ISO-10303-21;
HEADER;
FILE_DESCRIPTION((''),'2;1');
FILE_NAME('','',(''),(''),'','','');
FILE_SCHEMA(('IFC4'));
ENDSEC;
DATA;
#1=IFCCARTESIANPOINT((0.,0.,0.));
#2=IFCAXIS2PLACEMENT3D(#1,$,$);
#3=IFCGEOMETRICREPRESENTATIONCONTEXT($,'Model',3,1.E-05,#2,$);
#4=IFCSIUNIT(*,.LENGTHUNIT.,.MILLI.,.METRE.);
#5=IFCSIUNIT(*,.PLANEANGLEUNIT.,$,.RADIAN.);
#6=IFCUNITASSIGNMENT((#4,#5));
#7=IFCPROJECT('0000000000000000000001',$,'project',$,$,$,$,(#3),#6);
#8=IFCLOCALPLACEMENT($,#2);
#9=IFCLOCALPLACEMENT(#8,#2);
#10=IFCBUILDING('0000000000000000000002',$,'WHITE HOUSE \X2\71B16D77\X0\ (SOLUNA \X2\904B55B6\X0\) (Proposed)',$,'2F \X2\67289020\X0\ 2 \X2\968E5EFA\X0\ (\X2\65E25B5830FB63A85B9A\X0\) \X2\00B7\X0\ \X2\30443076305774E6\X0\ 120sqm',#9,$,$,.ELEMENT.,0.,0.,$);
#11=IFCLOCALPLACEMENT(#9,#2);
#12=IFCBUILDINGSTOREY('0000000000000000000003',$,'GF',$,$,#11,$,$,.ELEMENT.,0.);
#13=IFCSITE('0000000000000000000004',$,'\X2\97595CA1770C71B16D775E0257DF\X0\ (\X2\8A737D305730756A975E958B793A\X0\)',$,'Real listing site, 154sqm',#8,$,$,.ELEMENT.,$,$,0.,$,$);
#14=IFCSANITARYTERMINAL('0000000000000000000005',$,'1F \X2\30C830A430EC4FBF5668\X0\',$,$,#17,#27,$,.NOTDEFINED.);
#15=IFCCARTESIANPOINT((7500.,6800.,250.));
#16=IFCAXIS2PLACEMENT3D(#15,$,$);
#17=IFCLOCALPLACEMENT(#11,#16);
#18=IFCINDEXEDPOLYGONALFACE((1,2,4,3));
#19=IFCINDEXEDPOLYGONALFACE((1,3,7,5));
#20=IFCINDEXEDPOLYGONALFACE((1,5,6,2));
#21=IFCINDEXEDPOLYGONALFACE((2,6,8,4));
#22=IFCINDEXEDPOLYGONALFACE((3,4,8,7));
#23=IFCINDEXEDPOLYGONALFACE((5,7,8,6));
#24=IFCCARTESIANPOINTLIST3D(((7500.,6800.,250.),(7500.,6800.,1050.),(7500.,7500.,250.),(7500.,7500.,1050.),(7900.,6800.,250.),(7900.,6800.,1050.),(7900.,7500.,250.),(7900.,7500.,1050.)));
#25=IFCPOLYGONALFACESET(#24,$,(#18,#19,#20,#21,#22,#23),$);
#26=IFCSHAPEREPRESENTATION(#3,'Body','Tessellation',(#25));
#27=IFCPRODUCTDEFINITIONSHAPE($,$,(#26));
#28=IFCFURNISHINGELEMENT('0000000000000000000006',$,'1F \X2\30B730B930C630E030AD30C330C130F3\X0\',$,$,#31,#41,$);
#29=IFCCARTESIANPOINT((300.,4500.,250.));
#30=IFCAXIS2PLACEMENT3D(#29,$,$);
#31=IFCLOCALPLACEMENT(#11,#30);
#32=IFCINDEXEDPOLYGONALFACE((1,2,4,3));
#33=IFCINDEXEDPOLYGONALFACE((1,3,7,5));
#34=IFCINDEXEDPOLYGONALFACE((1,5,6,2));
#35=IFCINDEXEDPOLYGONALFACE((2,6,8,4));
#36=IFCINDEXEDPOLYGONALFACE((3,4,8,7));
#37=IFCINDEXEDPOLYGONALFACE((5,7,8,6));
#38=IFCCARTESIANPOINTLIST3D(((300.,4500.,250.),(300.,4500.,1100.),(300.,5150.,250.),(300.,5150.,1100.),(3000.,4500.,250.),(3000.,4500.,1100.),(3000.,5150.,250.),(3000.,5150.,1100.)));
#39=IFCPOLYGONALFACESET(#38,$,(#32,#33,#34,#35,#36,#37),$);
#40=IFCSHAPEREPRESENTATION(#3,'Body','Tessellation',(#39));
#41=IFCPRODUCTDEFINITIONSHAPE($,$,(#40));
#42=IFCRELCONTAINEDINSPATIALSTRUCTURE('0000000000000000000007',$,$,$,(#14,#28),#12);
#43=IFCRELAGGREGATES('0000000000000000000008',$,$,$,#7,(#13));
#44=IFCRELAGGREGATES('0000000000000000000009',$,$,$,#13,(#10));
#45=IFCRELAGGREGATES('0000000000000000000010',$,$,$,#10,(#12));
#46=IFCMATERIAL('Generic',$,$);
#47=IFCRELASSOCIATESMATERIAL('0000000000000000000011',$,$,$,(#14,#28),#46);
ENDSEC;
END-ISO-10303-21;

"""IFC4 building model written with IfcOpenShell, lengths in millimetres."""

from ifc_helpers import new_model, si_unit, frame, frame_2d, origin, place, context, project, spatial, rectangle, extrude, material, element, save


model = new_model("IFC4")

# Units and contexts
model_context = context("Model", 3, precision=1e-05, world=origin())
ifc_project = project(units=[si_unit("LENGTHUNIT", "METRE", prefix="MILLI"), si_unit("PLANEANGLEUNIT", "RADIAN")], contexts=[model_context])

# Site, building, storey
site_placement = place(None, origin())
site = spatial("IfcSite", under=ifc_project, at=site_placement, Name="静岡県熱海市域 (詳細地番非開示)", ObjectType="Real listing site, 154sqm", CompositionType="ELEMENT", RefElevation=0.0)
building_placement = place(site_placement, origin())
building = spatial("IfcBuilding", under=site, at=building_placement, Name="WHITE HOUSE 熱海 (SOLUNA 運営) (Proposed)", ObjectType="2F 木造 2 階建 (既存・推定) · いぶし瓦 120sqm", CompositionType="ELEMENT", ElevationOfRefHeight=0.0, ElevationOfTerrain=0.0)
storey_placement = place(building_placement, origin())
storey = spatial("IfcBuildingStorey", under=building, at=storey_placement, Name="GF", CompositionType="ELEMENT", Elevation=0.0)

# Shared definitions
ifc_material_1 = material(Name="Generic")

# Sanitary terminal
sanitary_terminal_1_placement = place(storey_placement, frame((7500.0, 6800.0, 250.0)))
element("IfcSanitaryTerminal", 1, at=sanitary_terminal_1_placement, inside=storey, material=ifc_material_1, Name="1F トイレ便器", PredefinedType="NOTDEFINED", context=model_context, shape_type="SweptSolid", body=[
    extrude(rectangle(XDim=400.0, YDim=700.0, at=frame_2d((200.0, 350.0))), frame((7500.0, 6800.0, 250.0)), (0.0, 0.0, 1.0), 800.0),
])

# Furnishing element
furnishing_1_placement = place(storey_placement, frame((300.0, 4500.0, 250.0)))
element("IfcFurnishingElement", 2, at=furnishing_1_placement, inside=storey, material=ifc_material_1, Name="1F システムキッチン", context=model_context, shape_type="SweptSolid", body=[
    extrude(rectangle(XDim=2700.0, YDim=650.0, at=frame_2d((1350.0, 325.0))), frame((300.0, 4500.0, 250.0)), (0.0, 0.0, 1.0), 850.0),
])

save(model, "model.ifc")
